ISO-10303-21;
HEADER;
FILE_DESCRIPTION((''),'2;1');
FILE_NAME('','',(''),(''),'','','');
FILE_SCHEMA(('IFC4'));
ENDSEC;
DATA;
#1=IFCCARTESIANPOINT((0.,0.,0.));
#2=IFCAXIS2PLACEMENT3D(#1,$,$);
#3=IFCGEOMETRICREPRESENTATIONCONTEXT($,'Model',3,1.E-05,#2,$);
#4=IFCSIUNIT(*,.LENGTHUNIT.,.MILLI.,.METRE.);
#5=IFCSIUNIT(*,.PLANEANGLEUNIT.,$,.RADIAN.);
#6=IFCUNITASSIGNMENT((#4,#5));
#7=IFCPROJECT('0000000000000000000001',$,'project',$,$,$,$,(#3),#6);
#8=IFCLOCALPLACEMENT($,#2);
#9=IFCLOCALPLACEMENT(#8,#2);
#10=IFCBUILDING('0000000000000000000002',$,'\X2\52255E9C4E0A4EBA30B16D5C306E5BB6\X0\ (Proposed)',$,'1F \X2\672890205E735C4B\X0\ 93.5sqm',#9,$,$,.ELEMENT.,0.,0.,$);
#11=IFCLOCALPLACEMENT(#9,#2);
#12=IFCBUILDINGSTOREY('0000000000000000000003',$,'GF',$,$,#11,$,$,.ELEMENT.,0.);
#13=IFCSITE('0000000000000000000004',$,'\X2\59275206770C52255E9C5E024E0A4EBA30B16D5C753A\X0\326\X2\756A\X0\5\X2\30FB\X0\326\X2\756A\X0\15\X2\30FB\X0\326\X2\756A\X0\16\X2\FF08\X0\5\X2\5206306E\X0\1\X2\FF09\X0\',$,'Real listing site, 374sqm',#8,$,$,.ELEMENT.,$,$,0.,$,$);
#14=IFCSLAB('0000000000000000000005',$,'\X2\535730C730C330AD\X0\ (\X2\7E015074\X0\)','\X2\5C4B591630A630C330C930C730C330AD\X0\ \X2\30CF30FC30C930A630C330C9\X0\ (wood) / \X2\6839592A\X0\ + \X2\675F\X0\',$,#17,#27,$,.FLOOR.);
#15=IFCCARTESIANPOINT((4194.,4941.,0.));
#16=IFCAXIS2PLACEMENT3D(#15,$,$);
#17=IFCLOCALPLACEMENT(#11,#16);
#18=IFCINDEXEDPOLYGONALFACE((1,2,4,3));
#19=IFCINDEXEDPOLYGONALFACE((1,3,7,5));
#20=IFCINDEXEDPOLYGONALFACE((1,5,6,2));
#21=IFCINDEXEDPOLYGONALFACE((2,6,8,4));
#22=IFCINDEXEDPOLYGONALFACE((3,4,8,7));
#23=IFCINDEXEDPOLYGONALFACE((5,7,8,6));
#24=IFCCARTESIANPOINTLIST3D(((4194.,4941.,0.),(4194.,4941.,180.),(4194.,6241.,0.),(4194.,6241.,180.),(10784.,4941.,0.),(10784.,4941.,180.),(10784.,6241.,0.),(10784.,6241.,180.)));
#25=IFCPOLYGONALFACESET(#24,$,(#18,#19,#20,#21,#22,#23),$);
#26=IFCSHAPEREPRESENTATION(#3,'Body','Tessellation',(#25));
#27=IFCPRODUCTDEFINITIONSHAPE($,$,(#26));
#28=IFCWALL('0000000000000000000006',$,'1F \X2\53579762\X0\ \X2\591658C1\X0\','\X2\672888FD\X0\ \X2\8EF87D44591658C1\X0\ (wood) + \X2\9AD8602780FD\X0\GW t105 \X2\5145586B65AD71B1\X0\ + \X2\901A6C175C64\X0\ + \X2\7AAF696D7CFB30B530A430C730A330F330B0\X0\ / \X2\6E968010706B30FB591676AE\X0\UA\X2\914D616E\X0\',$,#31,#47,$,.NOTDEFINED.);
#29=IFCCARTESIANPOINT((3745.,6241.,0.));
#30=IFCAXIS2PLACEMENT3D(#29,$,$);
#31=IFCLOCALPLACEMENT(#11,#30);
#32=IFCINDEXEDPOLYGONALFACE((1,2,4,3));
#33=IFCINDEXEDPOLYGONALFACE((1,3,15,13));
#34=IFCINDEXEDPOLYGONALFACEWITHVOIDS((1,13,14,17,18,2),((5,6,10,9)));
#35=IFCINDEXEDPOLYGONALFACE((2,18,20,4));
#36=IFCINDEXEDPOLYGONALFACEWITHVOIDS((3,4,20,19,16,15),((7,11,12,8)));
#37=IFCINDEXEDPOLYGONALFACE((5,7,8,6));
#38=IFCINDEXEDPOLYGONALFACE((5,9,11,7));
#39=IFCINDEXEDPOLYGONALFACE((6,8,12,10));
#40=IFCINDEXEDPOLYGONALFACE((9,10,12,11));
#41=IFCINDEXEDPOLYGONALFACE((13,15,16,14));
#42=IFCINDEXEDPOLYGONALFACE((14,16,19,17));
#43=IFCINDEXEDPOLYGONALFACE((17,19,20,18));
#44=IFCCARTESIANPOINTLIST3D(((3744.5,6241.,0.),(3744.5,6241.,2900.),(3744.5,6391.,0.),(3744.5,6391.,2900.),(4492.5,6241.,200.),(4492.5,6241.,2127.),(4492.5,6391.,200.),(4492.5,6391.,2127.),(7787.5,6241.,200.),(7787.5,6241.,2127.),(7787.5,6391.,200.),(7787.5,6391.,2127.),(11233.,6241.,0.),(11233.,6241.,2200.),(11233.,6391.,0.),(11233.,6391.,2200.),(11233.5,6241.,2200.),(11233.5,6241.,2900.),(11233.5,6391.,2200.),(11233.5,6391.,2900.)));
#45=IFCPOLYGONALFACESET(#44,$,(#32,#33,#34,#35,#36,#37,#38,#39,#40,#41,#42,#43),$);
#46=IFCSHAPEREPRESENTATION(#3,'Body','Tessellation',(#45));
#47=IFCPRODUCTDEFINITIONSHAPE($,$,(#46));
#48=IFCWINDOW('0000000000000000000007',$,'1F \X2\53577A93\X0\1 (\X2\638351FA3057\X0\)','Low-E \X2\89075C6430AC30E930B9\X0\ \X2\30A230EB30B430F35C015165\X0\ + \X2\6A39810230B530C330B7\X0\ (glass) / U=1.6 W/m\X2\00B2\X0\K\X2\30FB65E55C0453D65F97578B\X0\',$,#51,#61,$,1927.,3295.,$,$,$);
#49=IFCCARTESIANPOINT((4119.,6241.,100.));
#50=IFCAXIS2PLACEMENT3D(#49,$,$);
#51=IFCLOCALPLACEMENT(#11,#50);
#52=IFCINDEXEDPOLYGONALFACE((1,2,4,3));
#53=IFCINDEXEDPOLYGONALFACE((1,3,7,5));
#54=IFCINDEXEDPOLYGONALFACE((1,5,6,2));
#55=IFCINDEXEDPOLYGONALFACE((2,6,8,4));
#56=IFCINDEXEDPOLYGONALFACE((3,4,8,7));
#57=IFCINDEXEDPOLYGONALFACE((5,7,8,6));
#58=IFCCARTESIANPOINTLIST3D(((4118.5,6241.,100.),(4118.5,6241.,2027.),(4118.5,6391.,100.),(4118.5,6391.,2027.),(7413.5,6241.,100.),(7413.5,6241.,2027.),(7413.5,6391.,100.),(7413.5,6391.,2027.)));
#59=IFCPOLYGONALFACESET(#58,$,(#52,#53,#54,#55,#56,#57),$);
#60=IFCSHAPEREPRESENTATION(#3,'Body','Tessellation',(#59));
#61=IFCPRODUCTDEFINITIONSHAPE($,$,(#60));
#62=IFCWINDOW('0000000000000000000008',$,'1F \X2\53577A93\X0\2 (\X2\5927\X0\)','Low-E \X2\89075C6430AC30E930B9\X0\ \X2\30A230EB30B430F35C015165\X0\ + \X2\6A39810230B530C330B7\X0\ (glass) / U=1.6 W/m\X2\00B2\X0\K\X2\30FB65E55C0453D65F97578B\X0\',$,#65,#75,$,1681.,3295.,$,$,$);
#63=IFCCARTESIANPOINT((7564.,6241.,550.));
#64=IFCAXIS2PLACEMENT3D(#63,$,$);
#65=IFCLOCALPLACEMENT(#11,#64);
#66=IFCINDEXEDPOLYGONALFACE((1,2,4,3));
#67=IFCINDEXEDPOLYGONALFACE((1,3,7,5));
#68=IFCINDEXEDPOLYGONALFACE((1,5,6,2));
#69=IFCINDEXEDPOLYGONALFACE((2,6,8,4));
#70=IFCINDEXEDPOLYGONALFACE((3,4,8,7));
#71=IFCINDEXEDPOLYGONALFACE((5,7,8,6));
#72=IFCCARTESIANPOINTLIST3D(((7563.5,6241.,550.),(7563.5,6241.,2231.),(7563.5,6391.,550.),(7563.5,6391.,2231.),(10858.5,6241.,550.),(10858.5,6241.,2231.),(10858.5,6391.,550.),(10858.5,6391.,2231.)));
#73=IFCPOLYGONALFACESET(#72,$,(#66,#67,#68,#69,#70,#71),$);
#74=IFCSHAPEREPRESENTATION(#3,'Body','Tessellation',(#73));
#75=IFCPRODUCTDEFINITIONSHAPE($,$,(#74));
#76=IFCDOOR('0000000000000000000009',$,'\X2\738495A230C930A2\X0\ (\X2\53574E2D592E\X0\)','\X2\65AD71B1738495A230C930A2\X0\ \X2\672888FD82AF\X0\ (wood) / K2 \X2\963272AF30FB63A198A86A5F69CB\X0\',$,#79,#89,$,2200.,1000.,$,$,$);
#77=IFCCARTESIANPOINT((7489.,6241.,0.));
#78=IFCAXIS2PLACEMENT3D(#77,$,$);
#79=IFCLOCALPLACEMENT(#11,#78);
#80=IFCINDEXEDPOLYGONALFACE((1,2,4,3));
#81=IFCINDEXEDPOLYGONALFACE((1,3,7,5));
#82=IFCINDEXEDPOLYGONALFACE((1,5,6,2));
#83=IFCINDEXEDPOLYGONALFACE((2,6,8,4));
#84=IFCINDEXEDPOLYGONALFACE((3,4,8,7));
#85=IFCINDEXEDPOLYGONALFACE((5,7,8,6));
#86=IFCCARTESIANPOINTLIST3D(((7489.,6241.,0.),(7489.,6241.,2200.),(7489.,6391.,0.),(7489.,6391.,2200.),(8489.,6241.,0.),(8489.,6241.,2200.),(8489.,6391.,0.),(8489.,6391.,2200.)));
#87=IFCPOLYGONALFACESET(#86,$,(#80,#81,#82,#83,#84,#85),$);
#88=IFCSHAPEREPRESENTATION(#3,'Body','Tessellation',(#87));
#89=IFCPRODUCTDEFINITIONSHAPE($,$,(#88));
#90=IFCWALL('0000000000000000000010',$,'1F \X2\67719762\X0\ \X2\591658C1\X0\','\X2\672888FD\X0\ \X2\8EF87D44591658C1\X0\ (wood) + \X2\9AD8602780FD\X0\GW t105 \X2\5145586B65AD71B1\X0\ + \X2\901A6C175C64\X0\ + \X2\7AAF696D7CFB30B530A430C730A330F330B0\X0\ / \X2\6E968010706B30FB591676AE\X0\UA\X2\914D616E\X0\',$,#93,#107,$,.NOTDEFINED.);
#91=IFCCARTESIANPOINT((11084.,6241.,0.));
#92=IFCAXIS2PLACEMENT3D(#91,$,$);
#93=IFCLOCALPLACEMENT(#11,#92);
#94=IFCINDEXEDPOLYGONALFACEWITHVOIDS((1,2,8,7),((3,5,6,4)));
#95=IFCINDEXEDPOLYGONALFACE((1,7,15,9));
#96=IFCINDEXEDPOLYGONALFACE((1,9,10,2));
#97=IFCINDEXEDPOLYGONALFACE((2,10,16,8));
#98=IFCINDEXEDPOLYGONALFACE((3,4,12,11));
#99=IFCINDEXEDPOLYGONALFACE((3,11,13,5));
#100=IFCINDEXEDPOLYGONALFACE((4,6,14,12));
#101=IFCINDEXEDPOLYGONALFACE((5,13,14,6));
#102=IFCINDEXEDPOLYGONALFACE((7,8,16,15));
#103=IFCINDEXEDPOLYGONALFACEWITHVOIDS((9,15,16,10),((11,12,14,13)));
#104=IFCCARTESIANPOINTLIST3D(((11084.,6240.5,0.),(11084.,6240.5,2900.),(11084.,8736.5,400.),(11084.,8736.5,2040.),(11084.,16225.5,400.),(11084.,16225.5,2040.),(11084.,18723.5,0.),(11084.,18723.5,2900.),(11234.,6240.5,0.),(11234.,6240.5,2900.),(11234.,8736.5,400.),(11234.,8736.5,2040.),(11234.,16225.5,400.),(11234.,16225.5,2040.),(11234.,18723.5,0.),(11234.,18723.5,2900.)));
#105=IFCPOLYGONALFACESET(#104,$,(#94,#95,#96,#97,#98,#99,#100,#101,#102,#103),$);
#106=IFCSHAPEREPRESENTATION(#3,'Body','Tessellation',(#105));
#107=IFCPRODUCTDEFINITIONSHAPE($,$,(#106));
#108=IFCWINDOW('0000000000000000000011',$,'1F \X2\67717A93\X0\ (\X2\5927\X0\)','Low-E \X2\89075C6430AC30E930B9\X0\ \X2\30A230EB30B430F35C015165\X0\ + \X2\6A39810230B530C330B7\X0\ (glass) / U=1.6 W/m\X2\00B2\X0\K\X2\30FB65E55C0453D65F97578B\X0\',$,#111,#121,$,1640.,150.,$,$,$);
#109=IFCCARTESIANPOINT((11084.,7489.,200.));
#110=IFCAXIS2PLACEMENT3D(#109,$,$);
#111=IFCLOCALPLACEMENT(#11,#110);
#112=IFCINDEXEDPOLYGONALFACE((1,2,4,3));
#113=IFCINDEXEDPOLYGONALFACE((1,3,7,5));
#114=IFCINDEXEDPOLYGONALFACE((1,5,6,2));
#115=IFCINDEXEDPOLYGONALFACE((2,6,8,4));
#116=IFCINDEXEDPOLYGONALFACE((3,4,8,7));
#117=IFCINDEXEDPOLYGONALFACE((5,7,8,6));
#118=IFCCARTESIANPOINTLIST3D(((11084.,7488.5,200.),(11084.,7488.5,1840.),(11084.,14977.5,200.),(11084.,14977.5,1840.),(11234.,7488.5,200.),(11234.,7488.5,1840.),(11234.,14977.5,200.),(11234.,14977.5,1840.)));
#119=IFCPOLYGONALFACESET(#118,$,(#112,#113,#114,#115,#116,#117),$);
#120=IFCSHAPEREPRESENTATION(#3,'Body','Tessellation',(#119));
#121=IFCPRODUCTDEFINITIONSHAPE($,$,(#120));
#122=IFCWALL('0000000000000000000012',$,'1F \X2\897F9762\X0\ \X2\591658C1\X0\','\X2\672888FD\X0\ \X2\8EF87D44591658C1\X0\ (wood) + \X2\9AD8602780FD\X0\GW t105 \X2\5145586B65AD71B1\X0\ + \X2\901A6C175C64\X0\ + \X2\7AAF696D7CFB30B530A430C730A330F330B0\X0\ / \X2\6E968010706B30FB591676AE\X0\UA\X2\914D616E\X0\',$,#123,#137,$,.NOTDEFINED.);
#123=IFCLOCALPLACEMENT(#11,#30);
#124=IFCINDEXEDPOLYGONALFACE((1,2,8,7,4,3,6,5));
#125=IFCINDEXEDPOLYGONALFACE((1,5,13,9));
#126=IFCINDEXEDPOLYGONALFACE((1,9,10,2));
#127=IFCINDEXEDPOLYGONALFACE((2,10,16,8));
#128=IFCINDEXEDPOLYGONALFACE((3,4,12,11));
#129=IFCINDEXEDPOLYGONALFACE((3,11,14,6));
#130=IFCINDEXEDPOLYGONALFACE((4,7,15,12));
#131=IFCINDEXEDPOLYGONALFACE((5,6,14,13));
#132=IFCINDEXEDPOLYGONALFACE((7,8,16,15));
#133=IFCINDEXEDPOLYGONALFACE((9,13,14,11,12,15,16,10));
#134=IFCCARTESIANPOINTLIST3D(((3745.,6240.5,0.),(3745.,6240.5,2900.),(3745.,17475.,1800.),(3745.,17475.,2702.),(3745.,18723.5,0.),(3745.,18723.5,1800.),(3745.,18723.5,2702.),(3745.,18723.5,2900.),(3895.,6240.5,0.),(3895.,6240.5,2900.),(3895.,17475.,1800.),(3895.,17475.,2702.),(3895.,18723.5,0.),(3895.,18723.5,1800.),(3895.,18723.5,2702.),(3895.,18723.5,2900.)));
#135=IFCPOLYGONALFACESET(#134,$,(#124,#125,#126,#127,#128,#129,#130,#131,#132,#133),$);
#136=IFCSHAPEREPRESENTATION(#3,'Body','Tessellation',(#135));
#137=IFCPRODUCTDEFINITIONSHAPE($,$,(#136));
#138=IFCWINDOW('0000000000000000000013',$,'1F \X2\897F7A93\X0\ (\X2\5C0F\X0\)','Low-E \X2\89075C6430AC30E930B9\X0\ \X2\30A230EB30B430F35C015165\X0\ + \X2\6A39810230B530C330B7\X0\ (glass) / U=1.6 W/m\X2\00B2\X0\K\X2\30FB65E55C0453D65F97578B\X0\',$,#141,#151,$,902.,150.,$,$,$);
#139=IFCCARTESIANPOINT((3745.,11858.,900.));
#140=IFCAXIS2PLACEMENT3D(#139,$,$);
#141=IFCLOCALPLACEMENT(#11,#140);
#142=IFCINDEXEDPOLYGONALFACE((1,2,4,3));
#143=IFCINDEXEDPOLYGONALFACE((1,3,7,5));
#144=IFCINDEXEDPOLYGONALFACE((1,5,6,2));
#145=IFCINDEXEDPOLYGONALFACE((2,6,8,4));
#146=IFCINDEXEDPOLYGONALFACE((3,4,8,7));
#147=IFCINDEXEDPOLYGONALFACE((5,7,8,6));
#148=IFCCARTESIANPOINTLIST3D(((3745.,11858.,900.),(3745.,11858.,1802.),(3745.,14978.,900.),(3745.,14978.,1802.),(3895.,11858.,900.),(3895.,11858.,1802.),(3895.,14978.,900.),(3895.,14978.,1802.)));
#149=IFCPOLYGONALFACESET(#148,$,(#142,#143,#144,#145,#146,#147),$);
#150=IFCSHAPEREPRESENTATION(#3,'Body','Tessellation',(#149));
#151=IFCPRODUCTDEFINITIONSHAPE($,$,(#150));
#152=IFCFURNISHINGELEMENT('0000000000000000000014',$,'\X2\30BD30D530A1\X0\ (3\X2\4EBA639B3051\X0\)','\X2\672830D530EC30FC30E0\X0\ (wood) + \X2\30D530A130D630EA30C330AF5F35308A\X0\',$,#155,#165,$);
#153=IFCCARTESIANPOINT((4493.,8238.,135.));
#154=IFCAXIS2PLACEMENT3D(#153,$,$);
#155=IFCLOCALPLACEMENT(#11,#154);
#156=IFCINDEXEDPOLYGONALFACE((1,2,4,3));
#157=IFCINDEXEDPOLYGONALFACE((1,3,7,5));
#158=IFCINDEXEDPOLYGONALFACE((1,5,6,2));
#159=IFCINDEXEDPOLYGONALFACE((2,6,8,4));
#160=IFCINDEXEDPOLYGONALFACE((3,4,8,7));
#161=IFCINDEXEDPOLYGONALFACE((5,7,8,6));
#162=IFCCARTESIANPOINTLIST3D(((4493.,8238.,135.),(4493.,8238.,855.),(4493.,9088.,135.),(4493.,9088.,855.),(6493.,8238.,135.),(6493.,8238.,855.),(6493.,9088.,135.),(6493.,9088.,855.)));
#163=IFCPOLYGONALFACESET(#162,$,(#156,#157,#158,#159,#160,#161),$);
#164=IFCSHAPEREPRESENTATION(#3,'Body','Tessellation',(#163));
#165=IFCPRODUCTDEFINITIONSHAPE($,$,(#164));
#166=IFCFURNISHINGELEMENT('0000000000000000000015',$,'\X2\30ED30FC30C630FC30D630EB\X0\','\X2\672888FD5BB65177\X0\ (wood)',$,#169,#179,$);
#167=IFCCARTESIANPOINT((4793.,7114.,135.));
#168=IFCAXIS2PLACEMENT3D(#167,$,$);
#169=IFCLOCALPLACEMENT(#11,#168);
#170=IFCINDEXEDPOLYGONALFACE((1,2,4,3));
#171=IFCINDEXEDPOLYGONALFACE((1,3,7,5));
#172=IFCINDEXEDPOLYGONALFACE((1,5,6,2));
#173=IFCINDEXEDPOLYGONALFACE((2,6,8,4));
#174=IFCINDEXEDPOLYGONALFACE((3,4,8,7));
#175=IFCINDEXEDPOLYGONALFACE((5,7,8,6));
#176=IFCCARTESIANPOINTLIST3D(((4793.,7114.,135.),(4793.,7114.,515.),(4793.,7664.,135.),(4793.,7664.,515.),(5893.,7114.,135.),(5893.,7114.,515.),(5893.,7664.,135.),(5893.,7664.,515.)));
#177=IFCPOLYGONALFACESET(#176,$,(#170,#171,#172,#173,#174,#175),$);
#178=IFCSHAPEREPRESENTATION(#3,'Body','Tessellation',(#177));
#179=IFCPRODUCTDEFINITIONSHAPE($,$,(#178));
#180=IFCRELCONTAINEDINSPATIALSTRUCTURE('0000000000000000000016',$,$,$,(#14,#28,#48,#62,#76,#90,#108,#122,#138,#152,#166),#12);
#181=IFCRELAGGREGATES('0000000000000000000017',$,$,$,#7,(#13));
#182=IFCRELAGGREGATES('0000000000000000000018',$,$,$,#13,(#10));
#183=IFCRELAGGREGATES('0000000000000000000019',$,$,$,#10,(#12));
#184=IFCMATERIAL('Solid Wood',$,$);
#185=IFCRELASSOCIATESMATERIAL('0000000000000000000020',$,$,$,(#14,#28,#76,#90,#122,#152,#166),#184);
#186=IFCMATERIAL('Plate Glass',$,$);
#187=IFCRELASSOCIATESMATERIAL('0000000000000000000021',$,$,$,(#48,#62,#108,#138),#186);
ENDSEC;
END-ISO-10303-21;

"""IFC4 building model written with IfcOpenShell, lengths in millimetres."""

from ifc_helpers import new_model, si_unit, frame, frame_2d, origin, place, context, project, spatial, rectangle, extrude, material, element, fill, save


model = new_model("IFC4")

# Units and contexts
model_context = context("Model", 3, precision=1e-05, world=origin())
ifc_project = project(units=[si_unit("LENGTHUNIT", "METRE", prefix="MILLI"), si_unit("PLANEANGLEUNIT", "RADIAN")], contexts=[model_context])

# Site, building, storey
site_placement = place(None, origin())
site = spatial("IfcSite", under=ifc_project, at=site_placement, Name="大分県別府市上人ケ浜町326番5・326番15・326番16（5分の1）", ObjectType="Real listing site, 374sqm", CompositionType="ELEMENT", RefElevation=0.0)
building_placement = place(site_placement, origin())
building = spatial("IfcBuilding", under=site, at=building_placement, Name="別府上人ケ浜の家 (Proposed)", ObjectType="1F 木造平屋 93.5sqm", CompositionType="ELEMENT", ElevationOfRefHeight=0.0, ElevationOfTerrain=0.0)
storey_placement = place(building_placement, origin())
storey = spatial("IfcBuildingStorey", under=building, at=storey_placement, Name="GF", CompositionType="ELEMENT", Elevation=0.0)

# Slab
ifc_material_1 = material(Name="Solid Wood")
slab_1_placement = place(storey_placement, frame((4194.0, 4941.0, 0.0)))
element("IfcSlab", 1, at=slab_1_placement, inside=storey, material=ifc_material_1, Name="南デッキ (縁側)", Description="屋外ウッドデッキ ハードウッド (wood) / 根太 + 束", PredefinedType="FLOOR", context=model_context, shape_type="SweptSolid", body=[
    extrude(rectangle(XDim=6590.0, YDim=1300.0, at=frame_2d((3295.0, 650.0))), frame((4194.0, 4941.0, 0.0)), (0.0, 0.0, 1.0), 180.0),
])

# Wall, openings, windows, door
wall_1_placement = place(storey_placement, frame((3745.0, 6241.0, 0.0)))
wall_1 = element("IfcWall", 2, at=wall_1_placement, inside=storey, material=ifc_material_1, Name="1F 南面 外壁", Description="木製 軸組外壁 (wood) + 高性能GW t105 充填断熱 + 通気層 + 窯業系サイディング / 準耐火・外皮UA配慮", PredefinedType="NOTDEFINED", context=model_context, shape_type="SweptSolid", body=[
    extrude(rectangle(XDim=7489.0, YDim=150.0, at=frame_2d((3744.0, 75.0))), frame((3745.0, 6241.0, 0.0)), (0.0, 0.0, 1.0), 2900.0),
])
opening_1_placement = place(storey_placement, frame((4119.0, 6241.0, 100.0)))
opening_1 = element("IfcOpeningElement", 3, at=opening_1_placement, cuts=wall_1, PredefinedType="NOTDEFINED", context=model_context, shape_type="SweptSolid", body=[
    extrude(rectangle(XDim=3295.0, YDim=150.0, at=frame_2d((1647.0, 75.0))), frame((4119.0, 6241.0, 100.0)), (0.0, 0.0, 1.0), 1927.0),
])
opening_2_placement = place(storey_placement, frame((7564.0, 6241.0, 550.0)))
opening_2 = element("IfcOpeningElement", 4, at=opening_2_placement, cuts=wall_1, PredefinedType="NOTDEFINED", context=model_context, shape_type="SweptSolid", body=[
    extrude(rectangle(XDim=3295.0, YDim=150.0, at=frame_2d((1647.0, 75.0))), frame((7564.0, 6241.0, 550.0)), (0.0, 0.0, 1.0), 1681.0),
])
opening_3_placement = place(storey_placement, frame((7489.0, 6241.0, 0.0)))
opening_3 = element("IfcOpeningElement", 5, at=opening_3_placement, cuts=wall_1, PredefinedType="NOTDEFINED", context=model_context, shape_type="SweptSolid", body=[
    extrude(rectangle(XDim=1000.0, YDim=150.0, at=frame_2d((500.0, 75.0))), frame((7489.0, 6241.0, 0.0)), (0.0, 0.0, 1.0), 2200.0),
])
ifc_material_2 = material(Name="Plate Glass")
window_1_placement = place(storey_placement, frame((4119.0, 6241.0, 100.0)))
window_1 = element("IfcWindow", 6, at=window_1_placement, inside=storey, material=ifc_material_2, Name="1F 南窓1 (掃出し)", Description="Low-E 複層ガラス アルゴン封入 + 樹脂サッシ (glass) / U=1.6 W/m²K・日射取得型", OverallHeight=1927.0, OverallWidth=3295.0, context=model_context, shape_type="SweptSolid", body=[
    extrude(rectangle(XDim=3295.0, YDim=150.0, at=frame_2d((1647.0, 75.0))), frame((4119.0, 6241.0, 100.0)), (0.0, 0.0, 1.0), 1927.0),
])
fill(opening_1, window_1)
window_2_placement = place(storey_placement, frame((7564.0, 6241.0, 550.0)))
window_2 = element("IfcWindow", 7, at=window_2_placement, inside=storey, material=ifc_material_2, Name="1F 南窓2 (大)", Description="Low-E 複層ガラス アルゴン封入 + 樹脂サッシ (glass) / U=1.6 W/m²K・日射取得型", OverallHeight=1681.0, OverallWidth=3295.0, context=model_context, shape_type="SweptSolid", body=[
    extrude(rectangle(XDim=3295.0, YDim=150.0, at=frame_2d((1647.0, 75.0))), frame((7564.0, 6241.0, 550.0)), (0.0, 0.0, 1.0), 1681.0),
])
fill(opening_2, window_2)
door_placement = place(storey_placement, frame((7489.0, 6241.0, 0.0)))
door = element("IfcDoor", 8, at=door_placement, inside=storey, material=ifc_material_1, Name="玄関ドア (南中央)", Description="断熱玄関ドア 木製芯 (wood) / K2 防犯・採風機構", OverallHeight=2200.0, OverallWidth=1000.0, context=model_context, shape_type="SweptSolid", body=[
    extrude(rectangle(XDim=1000.0, YDim=150.0, at=frame_2d((500.0, 75.0))), frame((7489.0, 6241.0, 0.0)), (0.0, 0.0, 1.0), 2200.0),
])
fill(opening_3, door)

# Walls, openings, windows
wall_2_placement = place(storey_placement, frame((11084.0, 6241.0, 0.0)))
wall_2 = element("IfcWall", 9, at=wall_2_placement, inside=storey, material=ifc_material_1, Name="1F 東面 外壁", Description="木製 軸組外壁 (wood) + 高性能GW t105 充填断熱 + 通気層 + 窯業系サイディング / 準耐火・外皮UA配慮", PredefinedType="NOTDEFINED", context=model_context, shape_type="SweptSolid", body=[
    extrude(rectangle(XDim=150.0, YDim=12483.0, at=frame_2d((75.0, 6241.0))), frame((11084.0, 6241.0, 0.0)), (0.0, 0.0, 1.0), 2900.0),
])
opening_4_placement = place(storey_placement, frame((11084.0, 7489.0, 200.0)))
opening_4 = element("IfcOpeningElement", 10, at=opening_4_placement, cuts=wall_2, PredefinedType="NOTDEFINED", context=model_context, shape_type="SweptSolid", body=[
    extrude(rectangle(XDim=150.0, YDim=7489.0, at=frame_2d((75.0, 3744.0))), frame((11084.0, 7489.0, 200.0)), (0.0, 0.0, 1.0), 1640.0),
])
window_3_placement = place(storey_placement, frame((11084.0, 7489.0, 200.0)))
window_3 = element("IfcWindow", 11, at=window_3_placement, inside=storey, material=ifc_material_2, Name="1F 東窓 (大)", Description="Low-E 複層ガラス アルゴン封入 + 樹脂サッシ (glass) / U=1.6 W/m²K・日射取得型", OverallHeight=1640.0, OverallWidth=150.0, context=model_context, shape_type="SweptSolid", body=[
    extrude(rectangle(XDim=150.0, YDim=7489.0, at=frame_2d((75.0, 3744.0))), frame((11084.0, 7489.0, 200.0)), (0.0, 0.0, 1.0), 1640.0),
])
fill(opening_4, window_3)
wall_3_placement = place(storey_placement, frame((3745.0, 6241.0, 0.0)))
wall_3 = element("IfcWall", 12, at=wall_3_placement, inside=storey, material=ifc_material_1, Name="1F 西面 外壁", Description="木製 軸組外壁 (wood) + 高性能GW t105 充填断熱 + 通気層 + 窯業系サイディング / 準耐火・外皮UA配慮", PredefinedType="NOTDEFINED", context=model_context, shape_type="SweptSolid", body=[
    extrude(rectangle(XDim=150.0, YDim=12483.0, at=frame_2d((75.0, 6241.0))), frame((3745.0, 6241.0, 0.0)), (0.0, 0.0, 1.0), 2900.0),
])
opening_5_placement = place(storey_placement, frame((3745.0, 11858.0, 900.0)))
opening_5 = element("IfcOpeningElement", 13, at=opening_5_placement, cuts=wall_3, PredefinedType="NOTDEFINED", context=model_context, shape_type="SweptSolid", body=[
    extrude(rectangle(XDim=150.0, YDim=3120.0, at=frame_2d((75.0, 1560.0))), frame((3745.0, 11858.0, 900.0)), (0.0, 0.0, 1.0), 902.0),
])
window_4_placement = place(storey_placement, frame((3745.0, 11858.0, 900.0)))
window_4 = element("IfcWindow", 14, at=window_4_placement, inside=storey, material=ifc_material_2, Name="1F 西窓 (小)", Description="Low-E 複層ガラス アルゴン封入 + 樹脂サッシ (glass) / U=1.6 W/m²K・日射取得型", OverallHeight=902.0, OverallWidth=150.0, context=model_context, shape_type="SweptSolid", body=[
    extrude(rectangle(XDim=150.0, YDim=3120.0, at=frame_2d((75.0, 1560.0))), frame((3745.0, 11858.0, 900.0)), (0.0, 0.0, 1.0), 902.0),
])
fill(opening_5, window_4)

# Furnishing elements
furnishing_1_placement = place(storey_placement, frame((4493.0, 8238.0, 135.0)))
element("IfcFurnishingElement", 15, at=furnishing_1_placement, inside=storey, material=ifc_material_1, Name="ソファ (3人掛け)", Description="木フレーム (wood) + ファブリック張り", context=model_context, shape_type="SweptSolid", body=[
    extrude(rectangle(XDim=2000.0, YDim=850.0, at=frame_2d((1000.0, 425.0))), frame((4493.0, 8238.0, 135.0)), (0.0, 0.0, 1.0), 720.0),
])
furnishing_2_placement = place(storey_placement, frame((4793.0, 7114.0, 135.0)))
element("IfcFurnishingElement", 16, at=furnishing_2_placement, inside=storey, material=ifc_material_1, Name="ローテーブル", Description="木製家具 (wood)", context=model_context, shape_type="SweptSolid", body=[
    extrude(rectangle(XDim=1100.0, YDim=550.0, at=frame_2d((550.0, 275.0))), frame((4793.0, 7114.0, 135.0)), (0.0, 0.0, 1.0), 380.0),
])

save(model, "model.ifc")
